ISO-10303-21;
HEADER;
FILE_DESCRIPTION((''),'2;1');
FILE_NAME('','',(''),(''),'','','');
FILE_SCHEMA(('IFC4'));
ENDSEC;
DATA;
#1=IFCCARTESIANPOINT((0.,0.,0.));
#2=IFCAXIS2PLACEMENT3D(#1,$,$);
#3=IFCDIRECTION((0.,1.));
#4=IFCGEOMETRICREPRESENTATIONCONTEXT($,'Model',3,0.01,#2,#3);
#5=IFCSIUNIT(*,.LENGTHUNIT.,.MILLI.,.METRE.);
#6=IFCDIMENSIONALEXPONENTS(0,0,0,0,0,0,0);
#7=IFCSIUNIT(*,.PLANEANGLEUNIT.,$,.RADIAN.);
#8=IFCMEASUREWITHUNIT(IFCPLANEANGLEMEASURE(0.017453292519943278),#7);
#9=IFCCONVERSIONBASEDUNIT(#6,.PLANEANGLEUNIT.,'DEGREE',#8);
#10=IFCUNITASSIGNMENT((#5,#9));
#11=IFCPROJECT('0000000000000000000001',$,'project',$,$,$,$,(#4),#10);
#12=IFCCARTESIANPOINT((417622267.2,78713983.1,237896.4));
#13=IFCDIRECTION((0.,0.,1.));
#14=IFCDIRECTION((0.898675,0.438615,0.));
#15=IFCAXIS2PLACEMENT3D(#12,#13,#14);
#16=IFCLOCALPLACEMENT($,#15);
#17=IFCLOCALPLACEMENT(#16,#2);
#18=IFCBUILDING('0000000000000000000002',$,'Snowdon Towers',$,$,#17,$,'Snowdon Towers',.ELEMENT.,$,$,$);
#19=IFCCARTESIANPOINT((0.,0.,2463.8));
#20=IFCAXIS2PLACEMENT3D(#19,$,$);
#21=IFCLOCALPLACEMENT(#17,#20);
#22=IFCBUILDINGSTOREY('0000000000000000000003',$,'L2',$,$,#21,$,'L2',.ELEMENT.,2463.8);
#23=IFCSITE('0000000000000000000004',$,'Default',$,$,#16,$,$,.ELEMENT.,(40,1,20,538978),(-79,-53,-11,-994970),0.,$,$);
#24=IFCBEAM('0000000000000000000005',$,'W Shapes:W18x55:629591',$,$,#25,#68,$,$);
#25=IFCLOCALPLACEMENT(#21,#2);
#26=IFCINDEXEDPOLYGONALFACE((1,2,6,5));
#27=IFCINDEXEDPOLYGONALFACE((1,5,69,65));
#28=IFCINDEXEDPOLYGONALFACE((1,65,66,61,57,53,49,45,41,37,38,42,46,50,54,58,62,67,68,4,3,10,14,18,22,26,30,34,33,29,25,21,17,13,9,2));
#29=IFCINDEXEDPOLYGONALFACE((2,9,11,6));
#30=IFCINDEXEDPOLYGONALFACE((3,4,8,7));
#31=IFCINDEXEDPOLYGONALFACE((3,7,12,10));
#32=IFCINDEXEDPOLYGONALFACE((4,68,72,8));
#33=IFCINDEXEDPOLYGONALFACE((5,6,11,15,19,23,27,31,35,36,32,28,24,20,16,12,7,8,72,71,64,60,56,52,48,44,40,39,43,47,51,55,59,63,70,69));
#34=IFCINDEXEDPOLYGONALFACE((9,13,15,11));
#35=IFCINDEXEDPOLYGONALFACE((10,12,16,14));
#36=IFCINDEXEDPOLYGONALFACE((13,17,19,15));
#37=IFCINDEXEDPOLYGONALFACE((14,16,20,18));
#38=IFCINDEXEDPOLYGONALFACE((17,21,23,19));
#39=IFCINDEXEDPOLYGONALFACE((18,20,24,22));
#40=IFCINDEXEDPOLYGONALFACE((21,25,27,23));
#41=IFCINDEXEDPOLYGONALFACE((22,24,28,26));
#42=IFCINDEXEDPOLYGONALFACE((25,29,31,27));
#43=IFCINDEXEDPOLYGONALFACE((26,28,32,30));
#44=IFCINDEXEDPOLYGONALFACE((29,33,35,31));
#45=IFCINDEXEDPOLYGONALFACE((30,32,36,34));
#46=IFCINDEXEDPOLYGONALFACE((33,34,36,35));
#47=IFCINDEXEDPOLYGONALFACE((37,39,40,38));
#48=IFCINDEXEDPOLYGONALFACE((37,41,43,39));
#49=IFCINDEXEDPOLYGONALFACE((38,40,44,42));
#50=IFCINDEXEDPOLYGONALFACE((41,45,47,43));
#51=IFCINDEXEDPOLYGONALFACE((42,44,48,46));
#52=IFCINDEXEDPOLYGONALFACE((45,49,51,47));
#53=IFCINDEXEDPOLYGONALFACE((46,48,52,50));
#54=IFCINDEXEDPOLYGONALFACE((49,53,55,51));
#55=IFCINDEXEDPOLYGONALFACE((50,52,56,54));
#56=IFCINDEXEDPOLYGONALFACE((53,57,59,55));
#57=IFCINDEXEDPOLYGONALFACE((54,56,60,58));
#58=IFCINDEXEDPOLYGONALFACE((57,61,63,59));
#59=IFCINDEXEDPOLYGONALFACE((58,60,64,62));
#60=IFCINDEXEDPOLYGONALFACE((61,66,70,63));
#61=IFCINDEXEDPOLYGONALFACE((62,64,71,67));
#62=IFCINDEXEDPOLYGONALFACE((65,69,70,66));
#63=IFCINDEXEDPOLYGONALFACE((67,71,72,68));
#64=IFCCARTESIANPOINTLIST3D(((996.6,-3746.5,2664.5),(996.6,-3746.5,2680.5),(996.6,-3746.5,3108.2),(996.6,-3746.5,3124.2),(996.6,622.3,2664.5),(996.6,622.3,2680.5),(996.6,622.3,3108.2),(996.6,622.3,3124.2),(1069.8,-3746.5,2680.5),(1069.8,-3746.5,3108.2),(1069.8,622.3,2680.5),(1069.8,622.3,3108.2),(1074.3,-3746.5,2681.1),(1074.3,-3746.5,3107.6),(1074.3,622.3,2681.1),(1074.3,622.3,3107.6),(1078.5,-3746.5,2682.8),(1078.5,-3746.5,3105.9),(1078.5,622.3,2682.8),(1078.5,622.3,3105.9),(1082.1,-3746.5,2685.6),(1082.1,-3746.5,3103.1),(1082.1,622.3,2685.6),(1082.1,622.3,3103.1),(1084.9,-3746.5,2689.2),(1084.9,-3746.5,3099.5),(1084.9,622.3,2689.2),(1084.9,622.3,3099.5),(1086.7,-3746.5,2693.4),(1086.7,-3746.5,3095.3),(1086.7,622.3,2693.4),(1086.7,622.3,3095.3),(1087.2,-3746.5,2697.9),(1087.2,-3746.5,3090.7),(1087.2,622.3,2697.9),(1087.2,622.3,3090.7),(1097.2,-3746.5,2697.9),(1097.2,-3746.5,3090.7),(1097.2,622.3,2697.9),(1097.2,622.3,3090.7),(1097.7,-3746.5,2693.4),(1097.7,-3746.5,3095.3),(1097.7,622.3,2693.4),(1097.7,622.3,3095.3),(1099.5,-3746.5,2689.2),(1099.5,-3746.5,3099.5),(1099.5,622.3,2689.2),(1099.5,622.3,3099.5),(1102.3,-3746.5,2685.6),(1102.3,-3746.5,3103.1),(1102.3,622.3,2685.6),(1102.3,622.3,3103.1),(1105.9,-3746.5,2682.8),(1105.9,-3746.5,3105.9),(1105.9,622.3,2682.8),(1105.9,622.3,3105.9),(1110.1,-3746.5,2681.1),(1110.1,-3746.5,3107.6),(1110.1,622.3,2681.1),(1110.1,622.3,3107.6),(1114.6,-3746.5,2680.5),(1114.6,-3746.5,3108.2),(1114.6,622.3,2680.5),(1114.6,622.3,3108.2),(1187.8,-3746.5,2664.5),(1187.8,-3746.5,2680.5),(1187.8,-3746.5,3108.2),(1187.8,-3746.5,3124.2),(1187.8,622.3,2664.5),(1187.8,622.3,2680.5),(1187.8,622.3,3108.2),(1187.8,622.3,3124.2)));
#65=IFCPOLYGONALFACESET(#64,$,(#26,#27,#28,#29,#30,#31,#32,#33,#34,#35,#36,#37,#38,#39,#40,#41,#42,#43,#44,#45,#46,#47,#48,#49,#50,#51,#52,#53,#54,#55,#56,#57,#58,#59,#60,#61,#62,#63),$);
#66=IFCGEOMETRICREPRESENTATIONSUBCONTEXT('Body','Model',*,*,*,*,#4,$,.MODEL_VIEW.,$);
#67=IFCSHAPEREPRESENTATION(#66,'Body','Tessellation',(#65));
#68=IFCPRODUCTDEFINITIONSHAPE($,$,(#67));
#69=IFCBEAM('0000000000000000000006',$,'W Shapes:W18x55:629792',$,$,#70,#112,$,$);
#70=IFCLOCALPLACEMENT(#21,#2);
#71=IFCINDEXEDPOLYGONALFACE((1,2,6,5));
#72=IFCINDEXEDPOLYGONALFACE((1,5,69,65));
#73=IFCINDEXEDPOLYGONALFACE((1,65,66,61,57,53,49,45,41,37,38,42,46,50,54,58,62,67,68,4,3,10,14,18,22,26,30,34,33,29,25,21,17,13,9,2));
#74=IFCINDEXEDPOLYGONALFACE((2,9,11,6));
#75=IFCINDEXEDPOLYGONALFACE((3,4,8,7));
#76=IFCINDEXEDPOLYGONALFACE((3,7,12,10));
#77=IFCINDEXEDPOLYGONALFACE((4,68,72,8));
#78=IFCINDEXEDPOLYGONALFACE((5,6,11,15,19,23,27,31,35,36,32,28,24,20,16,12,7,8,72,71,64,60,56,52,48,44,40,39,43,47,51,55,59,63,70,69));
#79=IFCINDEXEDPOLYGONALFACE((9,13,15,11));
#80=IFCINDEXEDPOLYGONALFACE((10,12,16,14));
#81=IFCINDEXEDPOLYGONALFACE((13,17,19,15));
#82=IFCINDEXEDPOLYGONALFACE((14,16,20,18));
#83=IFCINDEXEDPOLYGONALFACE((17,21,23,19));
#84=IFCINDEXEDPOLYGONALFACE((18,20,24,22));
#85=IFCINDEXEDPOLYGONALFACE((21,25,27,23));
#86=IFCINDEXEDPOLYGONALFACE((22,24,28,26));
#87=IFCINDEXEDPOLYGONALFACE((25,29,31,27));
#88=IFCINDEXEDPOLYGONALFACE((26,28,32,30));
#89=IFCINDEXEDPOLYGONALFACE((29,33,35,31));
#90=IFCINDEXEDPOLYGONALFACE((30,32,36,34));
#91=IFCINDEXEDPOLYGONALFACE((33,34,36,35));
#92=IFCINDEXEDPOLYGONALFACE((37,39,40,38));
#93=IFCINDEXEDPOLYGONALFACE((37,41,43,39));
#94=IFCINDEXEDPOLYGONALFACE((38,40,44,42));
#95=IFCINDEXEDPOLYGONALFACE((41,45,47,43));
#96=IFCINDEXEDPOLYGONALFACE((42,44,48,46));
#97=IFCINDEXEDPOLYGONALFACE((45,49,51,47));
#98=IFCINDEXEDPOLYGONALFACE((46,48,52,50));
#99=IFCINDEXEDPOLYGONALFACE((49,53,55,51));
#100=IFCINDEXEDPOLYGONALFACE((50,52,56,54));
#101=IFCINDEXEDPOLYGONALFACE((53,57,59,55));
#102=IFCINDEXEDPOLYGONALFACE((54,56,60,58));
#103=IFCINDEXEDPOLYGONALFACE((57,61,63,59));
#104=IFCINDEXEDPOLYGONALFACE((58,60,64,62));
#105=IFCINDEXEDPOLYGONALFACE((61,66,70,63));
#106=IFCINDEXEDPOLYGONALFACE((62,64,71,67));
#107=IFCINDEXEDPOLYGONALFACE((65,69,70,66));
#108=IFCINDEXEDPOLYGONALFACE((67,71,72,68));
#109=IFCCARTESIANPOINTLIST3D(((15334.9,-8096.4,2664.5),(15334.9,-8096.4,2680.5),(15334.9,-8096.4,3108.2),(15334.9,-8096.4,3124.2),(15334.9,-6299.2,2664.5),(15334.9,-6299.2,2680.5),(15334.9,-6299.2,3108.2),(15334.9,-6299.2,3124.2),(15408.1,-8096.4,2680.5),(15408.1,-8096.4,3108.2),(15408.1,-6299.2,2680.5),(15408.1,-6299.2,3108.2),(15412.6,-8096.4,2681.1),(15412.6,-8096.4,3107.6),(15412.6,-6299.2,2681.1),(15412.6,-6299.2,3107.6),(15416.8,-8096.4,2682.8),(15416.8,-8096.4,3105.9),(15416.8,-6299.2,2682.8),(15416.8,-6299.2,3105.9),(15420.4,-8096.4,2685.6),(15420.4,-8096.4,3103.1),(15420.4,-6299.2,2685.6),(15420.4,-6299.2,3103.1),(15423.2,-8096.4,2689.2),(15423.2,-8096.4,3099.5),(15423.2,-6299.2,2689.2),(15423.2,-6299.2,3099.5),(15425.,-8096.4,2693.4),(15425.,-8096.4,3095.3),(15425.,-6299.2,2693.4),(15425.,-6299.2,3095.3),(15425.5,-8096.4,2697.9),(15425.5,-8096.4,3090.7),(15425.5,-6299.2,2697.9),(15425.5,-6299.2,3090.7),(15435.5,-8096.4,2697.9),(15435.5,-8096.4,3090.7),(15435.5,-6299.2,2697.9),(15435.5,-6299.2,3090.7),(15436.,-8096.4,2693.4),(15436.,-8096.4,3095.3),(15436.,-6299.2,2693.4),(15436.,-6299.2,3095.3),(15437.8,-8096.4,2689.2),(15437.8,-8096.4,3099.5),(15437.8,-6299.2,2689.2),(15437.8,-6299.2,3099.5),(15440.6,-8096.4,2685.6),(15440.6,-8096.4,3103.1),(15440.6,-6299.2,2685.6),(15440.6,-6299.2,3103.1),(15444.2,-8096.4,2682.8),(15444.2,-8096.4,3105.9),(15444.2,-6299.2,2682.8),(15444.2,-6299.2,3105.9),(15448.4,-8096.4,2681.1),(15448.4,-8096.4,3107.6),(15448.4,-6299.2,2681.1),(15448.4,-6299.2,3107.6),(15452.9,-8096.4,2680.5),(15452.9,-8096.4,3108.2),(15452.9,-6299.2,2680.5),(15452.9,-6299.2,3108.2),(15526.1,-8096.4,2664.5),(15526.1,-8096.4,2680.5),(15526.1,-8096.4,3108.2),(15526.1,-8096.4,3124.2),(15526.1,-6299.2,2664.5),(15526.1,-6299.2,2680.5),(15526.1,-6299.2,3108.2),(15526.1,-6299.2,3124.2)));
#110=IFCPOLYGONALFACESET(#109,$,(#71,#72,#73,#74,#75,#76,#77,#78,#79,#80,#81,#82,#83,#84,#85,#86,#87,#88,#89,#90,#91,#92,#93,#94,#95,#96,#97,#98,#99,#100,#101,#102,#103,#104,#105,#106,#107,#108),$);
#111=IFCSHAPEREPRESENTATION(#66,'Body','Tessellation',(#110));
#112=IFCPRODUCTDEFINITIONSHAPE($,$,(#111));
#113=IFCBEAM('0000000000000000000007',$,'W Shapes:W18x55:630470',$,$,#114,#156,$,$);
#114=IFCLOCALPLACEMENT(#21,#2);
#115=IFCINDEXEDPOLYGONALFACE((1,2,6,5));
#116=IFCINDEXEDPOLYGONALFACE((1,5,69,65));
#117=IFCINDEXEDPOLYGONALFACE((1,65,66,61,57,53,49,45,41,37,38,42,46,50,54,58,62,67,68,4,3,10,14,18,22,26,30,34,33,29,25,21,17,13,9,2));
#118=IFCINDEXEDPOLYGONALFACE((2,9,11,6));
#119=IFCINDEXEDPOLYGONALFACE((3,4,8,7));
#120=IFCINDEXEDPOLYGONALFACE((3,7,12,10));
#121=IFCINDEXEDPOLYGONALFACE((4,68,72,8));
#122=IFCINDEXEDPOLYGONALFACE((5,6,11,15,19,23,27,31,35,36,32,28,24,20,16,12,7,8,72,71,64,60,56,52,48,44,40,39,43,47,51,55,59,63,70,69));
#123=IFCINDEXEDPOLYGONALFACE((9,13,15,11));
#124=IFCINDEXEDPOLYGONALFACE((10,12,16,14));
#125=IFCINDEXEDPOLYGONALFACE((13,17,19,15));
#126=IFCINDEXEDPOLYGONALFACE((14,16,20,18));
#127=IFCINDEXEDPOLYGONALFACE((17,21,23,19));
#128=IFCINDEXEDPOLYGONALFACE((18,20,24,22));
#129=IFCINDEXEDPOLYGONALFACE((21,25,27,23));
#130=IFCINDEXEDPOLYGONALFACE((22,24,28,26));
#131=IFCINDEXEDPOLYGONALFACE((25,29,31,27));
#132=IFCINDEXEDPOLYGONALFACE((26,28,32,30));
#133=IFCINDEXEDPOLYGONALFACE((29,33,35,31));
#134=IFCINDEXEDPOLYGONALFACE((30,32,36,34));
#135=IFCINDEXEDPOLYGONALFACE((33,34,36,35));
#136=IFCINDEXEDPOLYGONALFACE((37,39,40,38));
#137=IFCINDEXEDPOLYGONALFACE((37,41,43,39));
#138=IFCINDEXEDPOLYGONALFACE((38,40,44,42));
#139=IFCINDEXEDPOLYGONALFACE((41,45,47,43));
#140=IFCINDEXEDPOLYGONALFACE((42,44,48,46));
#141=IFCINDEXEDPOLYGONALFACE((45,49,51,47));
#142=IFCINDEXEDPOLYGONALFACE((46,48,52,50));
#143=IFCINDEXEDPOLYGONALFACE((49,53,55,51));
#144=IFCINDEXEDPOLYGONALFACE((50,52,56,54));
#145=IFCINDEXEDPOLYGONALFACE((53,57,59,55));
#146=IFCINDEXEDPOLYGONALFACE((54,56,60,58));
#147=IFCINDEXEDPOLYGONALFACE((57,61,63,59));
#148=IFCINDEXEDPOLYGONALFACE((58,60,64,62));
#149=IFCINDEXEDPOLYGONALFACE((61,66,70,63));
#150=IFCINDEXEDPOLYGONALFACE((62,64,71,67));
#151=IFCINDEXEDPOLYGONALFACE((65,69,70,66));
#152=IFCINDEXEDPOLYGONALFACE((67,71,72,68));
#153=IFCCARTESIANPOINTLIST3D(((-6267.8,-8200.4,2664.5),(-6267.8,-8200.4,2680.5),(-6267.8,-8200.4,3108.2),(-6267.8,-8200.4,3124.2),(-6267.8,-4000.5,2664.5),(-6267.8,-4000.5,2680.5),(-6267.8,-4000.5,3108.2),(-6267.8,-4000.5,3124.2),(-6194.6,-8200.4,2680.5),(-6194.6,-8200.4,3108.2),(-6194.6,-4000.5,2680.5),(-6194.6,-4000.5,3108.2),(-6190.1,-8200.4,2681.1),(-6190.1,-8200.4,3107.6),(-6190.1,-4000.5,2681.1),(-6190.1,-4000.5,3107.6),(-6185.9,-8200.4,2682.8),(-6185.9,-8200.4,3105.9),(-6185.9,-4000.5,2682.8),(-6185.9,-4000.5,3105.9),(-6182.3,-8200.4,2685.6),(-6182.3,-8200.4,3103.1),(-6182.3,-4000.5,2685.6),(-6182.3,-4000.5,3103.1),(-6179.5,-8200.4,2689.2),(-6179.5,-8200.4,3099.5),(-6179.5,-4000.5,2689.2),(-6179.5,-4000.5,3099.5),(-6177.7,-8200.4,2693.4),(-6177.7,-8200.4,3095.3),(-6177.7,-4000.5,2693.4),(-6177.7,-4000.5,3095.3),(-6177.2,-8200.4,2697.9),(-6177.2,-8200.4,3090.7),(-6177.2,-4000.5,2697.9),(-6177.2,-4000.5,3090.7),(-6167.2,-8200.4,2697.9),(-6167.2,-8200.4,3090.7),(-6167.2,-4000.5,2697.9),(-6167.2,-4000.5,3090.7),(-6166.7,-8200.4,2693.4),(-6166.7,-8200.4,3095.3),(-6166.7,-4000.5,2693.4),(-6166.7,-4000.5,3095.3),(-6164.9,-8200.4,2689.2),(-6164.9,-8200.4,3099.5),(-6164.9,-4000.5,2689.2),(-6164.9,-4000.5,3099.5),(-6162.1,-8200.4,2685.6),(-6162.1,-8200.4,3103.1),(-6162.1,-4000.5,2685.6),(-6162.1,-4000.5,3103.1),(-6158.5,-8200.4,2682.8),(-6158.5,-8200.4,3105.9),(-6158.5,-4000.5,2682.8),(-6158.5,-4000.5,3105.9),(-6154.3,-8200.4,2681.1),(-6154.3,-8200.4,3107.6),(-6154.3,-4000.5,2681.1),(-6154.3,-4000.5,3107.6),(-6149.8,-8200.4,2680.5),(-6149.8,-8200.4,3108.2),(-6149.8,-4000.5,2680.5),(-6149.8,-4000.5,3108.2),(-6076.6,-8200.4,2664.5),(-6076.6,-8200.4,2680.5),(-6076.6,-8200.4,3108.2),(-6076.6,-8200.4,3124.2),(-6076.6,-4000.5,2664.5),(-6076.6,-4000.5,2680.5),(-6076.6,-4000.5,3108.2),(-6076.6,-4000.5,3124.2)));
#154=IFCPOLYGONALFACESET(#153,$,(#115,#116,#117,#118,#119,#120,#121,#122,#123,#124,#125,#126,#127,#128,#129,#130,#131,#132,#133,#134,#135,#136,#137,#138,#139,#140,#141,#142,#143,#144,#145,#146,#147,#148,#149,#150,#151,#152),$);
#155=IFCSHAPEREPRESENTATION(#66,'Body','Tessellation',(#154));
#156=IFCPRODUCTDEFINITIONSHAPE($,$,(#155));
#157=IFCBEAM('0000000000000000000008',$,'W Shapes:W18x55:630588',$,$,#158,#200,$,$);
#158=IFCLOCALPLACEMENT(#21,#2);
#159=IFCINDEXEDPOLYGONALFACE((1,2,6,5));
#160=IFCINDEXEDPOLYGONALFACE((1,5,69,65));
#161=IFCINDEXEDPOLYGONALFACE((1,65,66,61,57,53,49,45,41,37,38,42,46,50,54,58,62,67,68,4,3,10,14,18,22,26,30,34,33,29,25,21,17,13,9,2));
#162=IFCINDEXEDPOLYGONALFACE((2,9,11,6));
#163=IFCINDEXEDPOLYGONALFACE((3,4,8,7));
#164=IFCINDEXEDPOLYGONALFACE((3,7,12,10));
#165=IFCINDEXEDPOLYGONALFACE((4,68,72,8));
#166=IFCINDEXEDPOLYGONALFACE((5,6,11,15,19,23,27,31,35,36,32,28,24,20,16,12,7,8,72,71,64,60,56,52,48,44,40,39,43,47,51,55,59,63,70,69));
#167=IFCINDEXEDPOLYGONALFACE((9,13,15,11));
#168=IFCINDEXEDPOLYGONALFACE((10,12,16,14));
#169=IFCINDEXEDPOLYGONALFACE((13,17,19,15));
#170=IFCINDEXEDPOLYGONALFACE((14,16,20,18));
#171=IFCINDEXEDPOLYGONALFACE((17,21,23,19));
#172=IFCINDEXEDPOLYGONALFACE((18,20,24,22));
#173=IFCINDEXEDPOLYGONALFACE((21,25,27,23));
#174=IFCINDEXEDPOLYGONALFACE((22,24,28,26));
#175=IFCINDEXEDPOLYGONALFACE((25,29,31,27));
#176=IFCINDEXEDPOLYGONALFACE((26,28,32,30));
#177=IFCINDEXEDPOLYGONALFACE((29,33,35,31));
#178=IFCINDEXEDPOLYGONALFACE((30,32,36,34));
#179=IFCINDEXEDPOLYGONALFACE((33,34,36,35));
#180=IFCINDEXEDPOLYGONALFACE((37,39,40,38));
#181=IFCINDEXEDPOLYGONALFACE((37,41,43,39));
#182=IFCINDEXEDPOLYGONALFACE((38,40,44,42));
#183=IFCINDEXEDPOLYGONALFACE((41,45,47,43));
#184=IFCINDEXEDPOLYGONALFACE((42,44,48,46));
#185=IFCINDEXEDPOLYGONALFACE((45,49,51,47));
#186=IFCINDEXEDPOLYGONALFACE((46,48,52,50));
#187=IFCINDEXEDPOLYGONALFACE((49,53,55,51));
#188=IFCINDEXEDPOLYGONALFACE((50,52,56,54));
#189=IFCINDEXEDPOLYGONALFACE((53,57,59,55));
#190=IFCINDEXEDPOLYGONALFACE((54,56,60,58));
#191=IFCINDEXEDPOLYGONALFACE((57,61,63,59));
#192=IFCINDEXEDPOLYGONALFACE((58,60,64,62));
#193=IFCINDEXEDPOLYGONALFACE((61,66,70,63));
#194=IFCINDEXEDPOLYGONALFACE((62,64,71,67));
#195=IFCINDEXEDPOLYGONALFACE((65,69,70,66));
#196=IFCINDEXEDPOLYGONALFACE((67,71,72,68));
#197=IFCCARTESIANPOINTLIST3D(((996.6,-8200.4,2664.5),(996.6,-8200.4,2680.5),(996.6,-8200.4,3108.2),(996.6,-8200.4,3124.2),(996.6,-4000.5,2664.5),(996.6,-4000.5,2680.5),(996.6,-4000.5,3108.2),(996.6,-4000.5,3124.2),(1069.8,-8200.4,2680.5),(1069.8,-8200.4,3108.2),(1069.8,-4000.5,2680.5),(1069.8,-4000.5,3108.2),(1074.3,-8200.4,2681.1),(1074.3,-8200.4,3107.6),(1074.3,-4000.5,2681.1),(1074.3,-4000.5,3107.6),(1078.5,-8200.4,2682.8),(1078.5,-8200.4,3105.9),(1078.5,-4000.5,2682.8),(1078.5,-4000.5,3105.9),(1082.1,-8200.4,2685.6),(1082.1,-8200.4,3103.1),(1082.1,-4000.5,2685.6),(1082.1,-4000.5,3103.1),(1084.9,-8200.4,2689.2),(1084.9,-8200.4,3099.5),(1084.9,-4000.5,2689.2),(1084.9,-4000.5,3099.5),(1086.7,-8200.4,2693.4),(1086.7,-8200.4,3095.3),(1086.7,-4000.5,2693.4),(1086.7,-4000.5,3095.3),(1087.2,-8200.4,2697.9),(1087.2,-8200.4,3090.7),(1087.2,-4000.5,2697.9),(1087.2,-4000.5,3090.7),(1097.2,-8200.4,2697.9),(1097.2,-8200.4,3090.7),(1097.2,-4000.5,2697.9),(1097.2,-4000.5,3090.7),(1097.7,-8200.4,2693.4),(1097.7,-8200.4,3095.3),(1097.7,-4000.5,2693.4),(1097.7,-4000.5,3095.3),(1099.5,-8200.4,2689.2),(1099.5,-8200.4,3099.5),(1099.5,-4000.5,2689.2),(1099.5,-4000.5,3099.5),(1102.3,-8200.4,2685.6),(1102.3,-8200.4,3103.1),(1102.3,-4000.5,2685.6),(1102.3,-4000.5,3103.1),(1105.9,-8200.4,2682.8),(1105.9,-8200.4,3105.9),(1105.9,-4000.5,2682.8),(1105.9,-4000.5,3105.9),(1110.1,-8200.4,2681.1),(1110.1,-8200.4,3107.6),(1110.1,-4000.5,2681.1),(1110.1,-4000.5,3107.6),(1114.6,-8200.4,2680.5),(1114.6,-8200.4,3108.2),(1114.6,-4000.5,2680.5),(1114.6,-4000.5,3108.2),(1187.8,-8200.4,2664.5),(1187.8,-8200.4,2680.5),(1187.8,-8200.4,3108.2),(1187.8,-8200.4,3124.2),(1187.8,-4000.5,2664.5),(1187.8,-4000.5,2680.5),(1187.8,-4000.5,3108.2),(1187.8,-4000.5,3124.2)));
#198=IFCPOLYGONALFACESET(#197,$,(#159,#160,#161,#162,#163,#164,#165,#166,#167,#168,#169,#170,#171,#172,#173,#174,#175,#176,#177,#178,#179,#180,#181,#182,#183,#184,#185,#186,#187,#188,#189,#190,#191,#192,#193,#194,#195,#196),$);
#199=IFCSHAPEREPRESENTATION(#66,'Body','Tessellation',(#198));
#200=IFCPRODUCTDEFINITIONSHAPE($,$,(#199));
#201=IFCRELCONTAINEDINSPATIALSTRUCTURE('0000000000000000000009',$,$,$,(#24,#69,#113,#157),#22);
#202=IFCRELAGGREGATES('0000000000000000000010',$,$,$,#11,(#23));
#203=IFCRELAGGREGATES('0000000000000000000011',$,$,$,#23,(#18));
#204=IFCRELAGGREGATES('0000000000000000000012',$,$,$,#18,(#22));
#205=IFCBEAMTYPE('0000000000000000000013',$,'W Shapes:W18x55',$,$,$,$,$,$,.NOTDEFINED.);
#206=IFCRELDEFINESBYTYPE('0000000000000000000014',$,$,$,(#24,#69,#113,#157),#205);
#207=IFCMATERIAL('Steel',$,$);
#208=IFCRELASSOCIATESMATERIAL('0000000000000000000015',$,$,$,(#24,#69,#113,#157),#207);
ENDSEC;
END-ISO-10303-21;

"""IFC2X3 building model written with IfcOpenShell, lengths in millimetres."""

from ifc_helpers import new_model, entity, si_unit, converted_unit, direction, frame, frame_2d, origin, place, context, subcontext, project, spatial, i_section, extrude, material, type_object, element, save


model = new_model("IFC2X3")

# Units and contexts
model_context = context("Model", 3, precision=0.01, world=origin(), true_north=direction((0.0, 1.0)))
body_context = subcontext(model_context, "Body", "Model", "MODEL_VIEW")
ifc_project = project(units=[si_unit("LENGTHUNIT", "METRE", prefix="MILLI"), converted_unit("PLANEANGLEUNIT", "DEGREE", entity("IfcPlaneAngleMeasure", 0.017453292519943278), si_unit("PLANEANGLEUNIT", "RADIAN"), dimensions=[0, 0, 0, 0, 0, 0, 0])], contexts=[model_context])

# Site, building, storey
site_placement = place(None, frame((417622267.2, 78713983.1, 237896.4), z_axis=(0.0, 0.0, 1.0), x_axis=(0.898675, 0.438615, 0.0)))
site = spatial("IfcSite", under=ifc_project, at=site_placement, Name="Default", CompositionType="ELEMENT", RefLatitude=(40, 1, 20, 538978), RefLongitude=(-79, -53, -11, -994970), RefElevation=0.0)
building_placement = place(site_placement, origin())
building = spatial("IfcBuilding", under=site, at=building_placement, Name="Snowdon Towers", LongName="Snowdon Towers", CompositionType="ELEMENT")
storey_placement = place(building_placement, frame((0.0, 0.0, 2463.8)))
storey = spatial("IfcBuildingStorey", under=building, at=storey_placement, Name="L2", LongName="L2", CompositionType="ELEMENT", Elevation=2463.8)

# Shared definitions
ifc_material_1 = material(Name="Steel")

# Beams
beam_type_1 = type_object("IfcBeamType", Name="W Shapes:W18x55", PredefinedType="NOTDEFINED")
beam_1_placement = place(storey_placement, frame((1092.2, 762.0, 3124.2), z_axis=(0.0, 0.0, 1.0), x_axis=(0.0, -1.0, 0.0)))
element("IfcBeam", 1, at=beam_1_placement, inside=storey, type_object=beam_type_1, material=ifc_material_1, Name="W Shapes:W18x55:629591", context=body_context, shape_type="SweptSolid", body=[
    extrude(i_section(OverallWidth=191.3, OverallDepth=459.7, WebThickness=9.9, FlangeThickness=16.0, FilletRadius=17.5, at=frame_2d((0.0, 0.0), x_axis=(0.0, 1.0))), frame((139.7, 0.0, -229.9), z_axis=(1.0, 0.0, 0.0), x_axis=(0.0, 0.0, -1.0)), (0.0, 0.0, 1.0), 4368.8),
])
beam_2_placement = place(storey_placement, frame((15430.5, -6134.1, 3124.2), z_axis=(0.0, 0.0, 1.0), x_axis=(0.0, -1.0, 0.0)))
element("IfcBeam", 2, at=beam_2_placement, inside=storey, type_object=beam_type_1, material=ifc_material_1, Name="W Shapes:W18x55:629792", context=body_context, shape_type="SweptSolid", body=[
    extrude(i_section(OverallWidth=191.3, OverallDepth=459.7, WebThickness=9.9, FlangeThickness=16.0, FilletRadius=17.5, at=frame_2d((0.0, 0.0), x_axis=(0.0, 1.0))), frame((165.1, 0.0, -229.9), z_axis=(1.0, 0.0, 0.0), x_axis=(0.0, 0.0, -1.0)), (0.0, 0.0, 1.0), 1797.2),
])
beam_3_placement = place(storey_placement, frame((-6172.2, -3873.5, 3124.2), z_axis=(0.0, 0.0, 1.0), x_axis=(0.0, -1.0, 0.0)))
element("IfcBeam", 3, at=beam_3_placement, inside=storey, type_object=beam_type_1, material=ifc_material_1, Name="W Shapes:W18x55:630470", context=body_context, shape_type="SweptSolid", body=[
    extrude(i_section(OverallWidth=191.3, OverallDepth=459.7, WebThickness=9.9, FlangeThickness=16.0, FilletRadius=17.5, at=frame_2d((0.0, 0.0), x_axis=(0.0, 1.0))), frame((127.0, 0.0, -229.9), z_axis=(1.0, 0.0, 0.0), x_axis=(0.0, 0.0, -1.0)), (0.0, 0.0, 1.0), 4199.9),
])
beam_4_placement = place(storey_placement, frame((1092.2, -3873.5, 3124.2), z_axis=(0.0, 0.0, 1.0), x_axis=(0.0, -1.0, 0.0)))
element("IfcBeam", 4, at=beam_4_placement, inside=storey, type_object=beam_type_1, material=ifc_material_1, Name="W Shapes:W18x55:630588", context=body_context, shape_type="SweptSolid", body=[
    extrude(i_section(OverallWidth=191.3, OverallDepth=459.7, WebThickness=9.9, FlangeThickness=16.0, FilletRadius=17.5, at=frame_2d((0.0, 0.0), x_axis=(0.0, 1.0))), frame((127.0, 0.0, -229.9), z_axis=(1.0, 0.0, 0.0), x_axis=(0.0, 0.0, -1.0)), (0.0, 0.0, 1.0), 4199.9),
])

save(model, "model.ifc")
